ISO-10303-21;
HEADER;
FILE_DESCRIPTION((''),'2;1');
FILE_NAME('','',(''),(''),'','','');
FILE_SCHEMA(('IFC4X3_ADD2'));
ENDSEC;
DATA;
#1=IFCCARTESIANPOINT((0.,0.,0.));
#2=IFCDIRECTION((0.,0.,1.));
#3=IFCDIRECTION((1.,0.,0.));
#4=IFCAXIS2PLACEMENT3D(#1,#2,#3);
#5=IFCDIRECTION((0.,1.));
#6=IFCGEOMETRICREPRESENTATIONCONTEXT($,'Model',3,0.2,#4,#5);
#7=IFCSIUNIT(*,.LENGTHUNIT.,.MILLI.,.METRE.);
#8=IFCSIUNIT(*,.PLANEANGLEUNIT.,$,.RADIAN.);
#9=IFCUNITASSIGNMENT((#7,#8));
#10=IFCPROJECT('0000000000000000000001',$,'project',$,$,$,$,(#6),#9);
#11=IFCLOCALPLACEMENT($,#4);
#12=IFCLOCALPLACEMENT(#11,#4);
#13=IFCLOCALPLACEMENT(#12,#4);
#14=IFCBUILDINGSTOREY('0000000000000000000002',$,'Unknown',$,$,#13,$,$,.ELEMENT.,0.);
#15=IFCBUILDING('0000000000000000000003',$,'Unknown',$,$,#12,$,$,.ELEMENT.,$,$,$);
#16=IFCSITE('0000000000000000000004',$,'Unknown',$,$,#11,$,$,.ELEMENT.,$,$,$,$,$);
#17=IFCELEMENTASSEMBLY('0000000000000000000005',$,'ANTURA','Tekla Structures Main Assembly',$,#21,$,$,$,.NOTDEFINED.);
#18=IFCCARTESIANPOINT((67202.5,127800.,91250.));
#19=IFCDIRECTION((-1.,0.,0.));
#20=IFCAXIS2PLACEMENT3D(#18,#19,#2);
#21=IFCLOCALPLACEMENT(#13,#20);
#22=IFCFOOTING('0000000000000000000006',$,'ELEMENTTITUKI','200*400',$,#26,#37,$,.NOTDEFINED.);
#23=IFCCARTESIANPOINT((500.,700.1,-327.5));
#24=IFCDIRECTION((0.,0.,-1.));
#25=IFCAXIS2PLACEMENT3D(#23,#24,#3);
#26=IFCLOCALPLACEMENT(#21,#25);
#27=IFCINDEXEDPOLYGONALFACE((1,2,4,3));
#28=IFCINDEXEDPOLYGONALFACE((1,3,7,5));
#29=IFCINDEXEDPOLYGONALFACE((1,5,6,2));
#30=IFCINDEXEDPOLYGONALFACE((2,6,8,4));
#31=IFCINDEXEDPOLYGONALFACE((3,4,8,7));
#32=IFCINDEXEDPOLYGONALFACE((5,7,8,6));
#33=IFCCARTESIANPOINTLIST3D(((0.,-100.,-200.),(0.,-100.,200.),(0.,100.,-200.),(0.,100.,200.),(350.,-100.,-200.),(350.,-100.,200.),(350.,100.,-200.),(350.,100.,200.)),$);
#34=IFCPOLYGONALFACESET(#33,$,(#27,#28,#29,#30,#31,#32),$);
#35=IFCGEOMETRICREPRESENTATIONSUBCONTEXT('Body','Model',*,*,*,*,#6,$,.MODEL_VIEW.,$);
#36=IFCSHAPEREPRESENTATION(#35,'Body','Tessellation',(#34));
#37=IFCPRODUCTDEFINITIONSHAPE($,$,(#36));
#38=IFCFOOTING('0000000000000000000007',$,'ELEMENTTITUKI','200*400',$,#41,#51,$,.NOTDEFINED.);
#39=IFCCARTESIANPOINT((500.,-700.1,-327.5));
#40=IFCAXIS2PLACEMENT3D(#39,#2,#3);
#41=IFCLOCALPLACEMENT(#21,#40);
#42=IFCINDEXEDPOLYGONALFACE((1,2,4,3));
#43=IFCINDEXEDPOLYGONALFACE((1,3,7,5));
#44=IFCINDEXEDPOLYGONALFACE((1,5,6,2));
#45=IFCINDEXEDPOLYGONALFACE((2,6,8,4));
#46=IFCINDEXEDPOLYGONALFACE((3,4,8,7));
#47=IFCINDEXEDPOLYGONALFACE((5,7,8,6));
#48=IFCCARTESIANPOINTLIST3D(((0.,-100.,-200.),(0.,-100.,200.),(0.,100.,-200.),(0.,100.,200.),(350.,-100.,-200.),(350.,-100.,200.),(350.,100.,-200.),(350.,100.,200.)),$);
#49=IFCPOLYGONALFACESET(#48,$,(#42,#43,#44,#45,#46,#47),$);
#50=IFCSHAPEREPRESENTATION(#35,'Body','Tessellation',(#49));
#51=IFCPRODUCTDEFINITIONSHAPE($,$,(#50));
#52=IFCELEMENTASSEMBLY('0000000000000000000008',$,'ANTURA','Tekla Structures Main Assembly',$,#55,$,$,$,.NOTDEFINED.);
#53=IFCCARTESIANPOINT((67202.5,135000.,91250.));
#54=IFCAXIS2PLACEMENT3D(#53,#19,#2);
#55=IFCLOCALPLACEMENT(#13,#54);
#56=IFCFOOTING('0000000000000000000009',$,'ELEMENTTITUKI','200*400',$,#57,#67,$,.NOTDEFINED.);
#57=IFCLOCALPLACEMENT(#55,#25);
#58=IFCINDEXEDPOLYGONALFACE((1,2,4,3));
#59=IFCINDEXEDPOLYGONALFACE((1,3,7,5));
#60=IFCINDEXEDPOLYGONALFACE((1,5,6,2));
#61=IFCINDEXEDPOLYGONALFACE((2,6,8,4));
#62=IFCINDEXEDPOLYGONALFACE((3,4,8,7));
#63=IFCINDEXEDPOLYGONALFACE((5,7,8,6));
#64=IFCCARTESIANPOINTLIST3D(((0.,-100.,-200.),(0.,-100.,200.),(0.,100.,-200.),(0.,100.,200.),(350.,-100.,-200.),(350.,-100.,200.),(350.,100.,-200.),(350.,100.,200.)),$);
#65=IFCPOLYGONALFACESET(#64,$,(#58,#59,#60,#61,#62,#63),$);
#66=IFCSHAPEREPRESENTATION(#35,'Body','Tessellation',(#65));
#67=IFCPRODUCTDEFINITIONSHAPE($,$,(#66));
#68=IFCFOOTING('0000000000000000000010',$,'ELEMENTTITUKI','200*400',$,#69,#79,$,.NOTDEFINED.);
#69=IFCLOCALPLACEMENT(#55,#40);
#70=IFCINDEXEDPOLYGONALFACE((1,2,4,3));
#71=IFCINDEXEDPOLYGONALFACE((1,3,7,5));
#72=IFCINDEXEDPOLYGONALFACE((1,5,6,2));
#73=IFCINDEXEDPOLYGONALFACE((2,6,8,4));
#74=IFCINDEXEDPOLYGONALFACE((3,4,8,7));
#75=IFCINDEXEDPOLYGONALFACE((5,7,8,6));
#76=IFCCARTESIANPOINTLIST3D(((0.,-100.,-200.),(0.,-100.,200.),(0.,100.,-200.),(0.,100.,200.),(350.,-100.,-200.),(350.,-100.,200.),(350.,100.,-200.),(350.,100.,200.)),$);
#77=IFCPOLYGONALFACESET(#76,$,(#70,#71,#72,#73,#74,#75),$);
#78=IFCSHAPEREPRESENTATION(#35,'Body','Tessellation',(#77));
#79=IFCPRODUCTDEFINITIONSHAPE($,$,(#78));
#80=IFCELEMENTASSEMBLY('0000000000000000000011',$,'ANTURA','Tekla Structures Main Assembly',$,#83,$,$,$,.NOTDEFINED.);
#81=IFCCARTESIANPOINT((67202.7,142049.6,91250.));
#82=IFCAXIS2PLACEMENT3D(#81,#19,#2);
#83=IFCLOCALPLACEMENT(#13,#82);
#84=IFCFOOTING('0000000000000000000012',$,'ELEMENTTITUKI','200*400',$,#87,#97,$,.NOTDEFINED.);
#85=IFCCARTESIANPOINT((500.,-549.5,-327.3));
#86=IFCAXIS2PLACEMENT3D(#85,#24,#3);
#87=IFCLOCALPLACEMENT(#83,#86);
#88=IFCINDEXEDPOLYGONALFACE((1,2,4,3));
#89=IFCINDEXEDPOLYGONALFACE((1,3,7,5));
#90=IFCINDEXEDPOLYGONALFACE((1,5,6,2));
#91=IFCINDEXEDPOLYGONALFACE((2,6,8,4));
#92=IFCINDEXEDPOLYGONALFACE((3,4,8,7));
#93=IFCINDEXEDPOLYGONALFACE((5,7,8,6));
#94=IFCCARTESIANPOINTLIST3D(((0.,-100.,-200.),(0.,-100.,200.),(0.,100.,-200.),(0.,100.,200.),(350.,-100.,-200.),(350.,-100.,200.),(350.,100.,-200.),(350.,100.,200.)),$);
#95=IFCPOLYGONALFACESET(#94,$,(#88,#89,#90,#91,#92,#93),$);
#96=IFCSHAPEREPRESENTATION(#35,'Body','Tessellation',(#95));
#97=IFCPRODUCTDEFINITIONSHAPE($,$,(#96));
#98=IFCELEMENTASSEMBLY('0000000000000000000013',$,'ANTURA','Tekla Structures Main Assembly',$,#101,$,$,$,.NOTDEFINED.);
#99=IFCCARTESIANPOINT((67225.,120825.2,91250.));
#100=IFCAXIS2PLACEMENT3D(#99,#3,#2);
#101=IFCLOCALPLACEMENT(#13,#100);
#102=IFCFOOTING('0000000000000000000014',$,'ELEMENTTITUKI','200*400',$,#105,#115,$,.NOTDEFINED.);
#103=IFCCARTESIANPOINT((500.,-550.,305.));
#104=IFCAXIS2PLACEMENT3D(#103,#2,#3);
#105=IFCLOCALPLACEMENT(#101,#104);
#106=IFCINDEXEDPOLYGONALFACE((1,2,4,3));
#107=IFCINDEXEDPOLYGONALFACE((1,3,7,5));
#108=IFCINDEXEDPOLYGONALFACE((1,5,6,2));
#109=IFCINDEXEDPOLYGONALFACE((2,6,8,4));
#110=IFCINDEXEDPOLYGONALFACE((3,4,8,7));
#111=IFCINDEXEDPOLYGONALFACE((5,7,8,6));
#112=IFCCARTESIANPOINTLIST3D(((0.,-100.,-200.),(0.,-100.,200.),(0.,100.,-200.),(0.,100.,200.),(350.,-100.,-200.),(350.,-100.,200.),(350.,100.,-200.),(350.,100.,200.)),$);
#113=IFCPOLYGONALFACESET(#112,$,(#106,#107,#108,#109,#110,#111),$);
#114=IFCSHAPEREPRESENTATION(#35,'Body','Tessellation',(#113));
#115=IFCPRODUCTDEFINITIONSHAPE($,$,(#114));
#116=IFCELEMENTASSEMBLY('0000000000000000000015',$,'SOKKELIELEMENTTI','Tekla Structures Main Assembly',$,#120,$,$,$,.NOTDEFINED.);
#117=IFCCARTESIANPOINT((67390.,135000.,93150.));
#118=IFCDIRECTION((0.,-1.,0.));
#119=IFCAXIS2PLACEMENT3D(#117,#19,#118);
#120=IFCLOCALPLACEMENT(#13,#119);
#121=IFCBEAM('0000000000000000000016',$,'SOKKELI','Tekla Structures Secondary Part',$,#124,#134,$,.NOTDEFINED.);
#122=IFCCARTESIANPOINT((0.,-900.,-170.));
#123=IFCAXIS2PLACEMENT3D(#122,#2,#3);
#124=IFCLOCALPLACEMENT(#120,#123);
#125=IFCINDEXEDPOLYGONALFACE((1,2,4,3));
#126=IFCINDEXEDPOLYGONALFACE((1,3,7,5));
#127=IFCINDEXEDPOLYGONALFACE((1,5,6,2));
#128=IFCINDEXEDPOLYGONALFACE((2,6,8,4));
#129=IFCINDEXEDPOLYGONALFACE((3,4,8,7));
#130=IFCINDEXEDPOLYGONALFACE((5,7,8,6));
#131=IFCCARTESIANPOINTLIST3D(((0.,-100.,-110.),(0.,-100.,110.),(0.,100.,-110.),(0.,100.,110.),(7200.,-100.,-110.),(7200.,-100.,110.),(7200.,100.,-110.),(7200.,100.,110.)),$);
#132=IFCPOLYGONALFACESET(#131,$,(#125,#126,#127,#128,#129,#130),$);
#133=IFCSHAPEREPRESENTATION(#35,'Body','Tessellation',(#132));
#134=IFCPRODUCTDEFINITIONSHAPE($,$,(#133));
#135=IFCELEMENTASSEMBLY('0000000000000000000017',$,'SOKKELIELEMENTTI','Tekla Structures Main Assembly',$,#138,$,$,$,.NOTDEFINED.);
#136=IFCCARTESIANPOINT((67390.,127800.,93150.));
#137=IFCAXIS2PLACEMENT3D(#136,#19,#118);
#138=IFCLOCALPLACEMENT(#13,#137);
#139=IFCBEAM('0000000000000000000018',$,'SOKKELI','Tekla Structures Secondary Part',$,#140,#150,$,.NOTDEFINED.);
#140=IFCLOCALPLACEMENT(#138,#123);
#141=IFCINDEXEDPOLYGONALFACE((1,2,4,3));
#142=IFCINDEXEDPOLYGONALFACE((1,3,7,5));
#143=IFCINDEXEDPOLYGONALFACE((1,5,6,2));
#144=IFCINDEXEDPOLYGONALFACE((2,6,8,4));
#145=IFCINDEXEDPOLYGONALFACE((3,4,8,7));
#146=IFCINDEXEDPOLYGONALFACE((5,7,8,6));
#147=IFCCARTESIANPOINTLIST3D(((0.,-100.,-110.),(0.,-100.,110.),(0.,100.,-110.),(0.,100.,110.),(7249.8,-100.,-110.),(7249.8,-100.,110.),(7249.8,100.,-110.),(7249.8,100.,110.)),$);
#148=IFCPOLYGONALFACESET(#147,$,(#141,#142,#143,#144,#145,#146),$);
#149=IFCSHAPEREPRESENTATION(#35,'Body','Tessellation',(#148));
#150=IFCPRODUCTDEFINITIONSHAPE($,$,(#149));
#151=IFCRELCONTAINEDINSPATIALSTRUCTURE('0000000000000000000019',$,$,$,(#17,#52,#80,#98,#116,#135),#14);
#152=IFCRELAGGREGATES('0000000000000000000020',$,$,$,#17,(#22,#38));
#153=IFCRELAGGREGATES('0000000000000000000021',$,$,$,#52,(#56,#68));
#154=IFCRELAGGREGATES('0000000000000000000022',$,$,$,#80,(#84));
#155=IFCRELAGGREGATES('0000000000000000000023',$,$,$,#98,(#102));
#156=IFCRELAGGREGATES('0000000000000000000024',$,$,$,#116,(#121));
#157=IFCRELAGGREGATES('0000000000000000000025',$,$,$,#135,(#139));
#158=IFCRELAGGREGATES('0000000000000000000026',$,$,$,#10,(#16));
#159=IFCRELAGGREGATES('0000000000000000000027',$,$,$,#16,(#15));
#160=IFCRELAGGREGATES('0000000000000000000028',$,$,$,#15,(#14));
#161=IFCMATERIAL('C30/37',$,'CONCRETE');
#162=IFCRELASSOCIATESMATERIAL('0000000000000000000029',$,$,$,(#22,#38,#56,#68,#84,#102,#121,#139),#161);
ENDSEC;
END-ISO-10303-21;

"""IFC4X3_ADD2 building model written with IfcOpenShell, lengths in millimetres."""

from ifc_helpers import new_model, si_unit, direction, frame, origin_with_axes, place, context, subcontext, project, spatial, line, indexed_curve, outline, extrude, material, element, aggregate, save


model = new_model("IFC4X3_ADD2")

# Units and contexts
model_context = context("Model", 3, precision=0.2, world=origin_with_axes(), true_north=direction((0.0, 1.0)))
body_context = subcontext(model_context, "Body", "Model", "MODEL_VIEW")
ifc_project = project(units=[si_unit("LENGTHUNIT", "METRE", prefix="MILLI"), si_unit("PLANEANGLEUNIT", "RADIAN")], contexts=[model_context])

# Site, building, storey
site_placement = place(None, origin_with_axes())
site = spatial("IfcSite", under=ifc_project, at=site_placement, Name="Unknown", CompositionType="ELEMENT")
building_placement = place(site_placement, origin_with_axes())
building = spatial("IfcBuilding", under=site, at=building_placement, Name="Unknown", CompositionType="ELEMENT")
storey_placement = place(building_placement, origin_with_axes())
storey = spatial("IfcBuildingStorey", under=building, at=storey_placement, Name="Unknown", CompositionType="ELEMENT", Elevation=0.0)

# Shared definitions
ifc_material_1 = material(Name="C30/37", Category="CONCRETE")

# Element assembly, footings
assembly_1_placement = place(storey_placement, frame((67202.5, 127800.0, 91250.0), z_axis=(-1.0, 0.0, 0.0), x_axis=(0.0, 0.0, 1.0)))
assembly_1 = element("IfcElementAssembly", 1, at=assembly_1_placement, inside=storey, Name="ANTURA", Description="Tekla Structures Main Assembly", PredefinedType="NOTDEFINED")
footing_1_placement = place(assembly_1_placement, frame((500.0, 700.1, -327.5), z_axis=(0.0, 0.0, -1.0), x_axis=(1.0, 0.0, 0.0)))
footing_1 = element("IfcFooting", 2, at=footing_1_placement, material=ifc_material_1, Name="ELEMENTTITUKI", Description="200*400", PredefinedType="NOTDEFINED", context=body_context, shape_type="SolidModel", body=[
    extrude(outline(indexed_curve([(-200.0, -100.0), (200.0, -100.0), (200.0, 100.0), (-200.0, 100.0)], segments=[line(1, 2, 3, 4, 1)])), frame((0.0, 0.0, 0.0), z_axis=(-1.0, 0.0, 0.0), x_axis=(0.0, 0.0, 1.0)), (0.0, 0.0, -1.0), 350.0),
])
footing_2_placement = place(assembly_1_placement, frame((500.0, -700.1, -327.5), z_axis=(0.0, 0.0, 1.0), x_axis=(1.0, 0.0, 0.0)))
footing_2 = element("IfcFooting", 3, at=footing_2_placement, material=ifc_material_1, Name="ELEMENTTITUKI", Description="200*400", PredefinedType="NOTDEFINED", context=body_context, shape_type="SolidModel", body=[
    extrude(outline(indexed_curve([(-200.0, -100.0), (200.0, -100.0), (200.0, 100.0), (-200.0, 100.0)], segments=[line(1, 2, 3, 4, 1)])), frame((0.0, 0.0, 0.0), z_axis=(-1.0, 0.0, 0.0), x_axis=(0.0, 0.0, 1.0)), (0.0, 0.0, -1.0), 350.0),
])
aggregate(assembly_1, [footing_1, footing_2])

# Element assembly, footings
assembly_2_placement = place(storey_placement, frame((67202.5, 135000.0, 91250.0), z_axis=(-1.0, 0.0, 0.0), x_axis=(0.0, 0.0, 1.0)))
assembly_2 = element("IfcElementAssembly", 4, at=assembly_2_placement, inside=storey, Name="ANTURA", Description="Tekla Structures Main Assembly", PredefinedType="NOTDEFINED")
footing_3_placement = place(assembly_2_placement, frame((500.0, 700.1, -327.5), z_axis=(0.0, 0.0, -1.0), x_axis=(1.0, 0.0, 0.0)))
footing_3 = element("IfcFooting", 5, at=footing_3_placement, material=ifc_material_1, Name="ELEMENTTITUKI", Description="200*400", PredefinedType="NOTDEFINED", context=body_context, shape_type="SolidModel", body=[
    extrude(outline(indexed_curve([(-200.0, -100.0), (200.0, -100.0), (200.0, 100.0), (-200.0, 100.0)], segments=[line(1, 2, 3, 4, 1)])), frame((0.0, 0.0, 0.0), z_axis=(-1.0, 0.0, 0.0), x_axis=(0.0, 0.0, 1.0)), (0.0, 0.0, -1.0), 350.0),
])
footing_4_placement = place(assembly_2_placement, frame((500.0, -700.1, -327.5), z_axis=(0.0, 0.0, 1.0), x_axis=(1.0, 0.0, 0.0)))
footing_4 = element("IfcFooting", 6, at=footing_4_placement, material=ifc_material_1, Name="ELEMENTTITUKI", Description="200*400", PredefinedType="NOTDEFINED", context=body_context, shape_type="SolidModel", body=[
    extrude(outline(indexed_curve([(-200.0, -100.0), (200.0, -100.0), (200.0, 100.0), (-200.0, 100.0)], segments=[line(1, 2, 3, 4, 1)])), frame((0.0, 0.0, 0.0), z_axis=(-1.0, 0.0, 0.0), x_axis=(0.0, 0.0, 1.0)), (0.0, 0.0, -1.0), 350.0),
])
aggregate(assembly_2, [footing_3, footing_4])

# Element assemblies, footings
assembly_3_placement = place(storey_placement, frame((67202.7, 142049.6, 91250.0), z_axis=(-1.0, 0.0, 0.0), x_axis=(0.0, 0.0, 1.0)))
assembly_3 = element("IfcElementAssembly", 7, at=assembly_3_placement, inside=storey, Name="ANTURA", Description="Tekla Structures Main Assembly", PredefinedType="NOTDEFINED")
footing_5_placement = place(assembly_3_placement, frame((500.0, -549.5, -327.3), z_axis=(0.0, 0.0, -1.0), x_axis=(1.0, 0.0, 0.0)))
footing_5 = element("IfcFooting", 8, at=footing_5_placement, material=ifc_material_1, Name="ELEMENTTITUKI", Description="200*400", PredefinedType="NOTDEFINED", context=body_context, shape_type="SolidModel", body=[
    extrude(outline(indexed_curve([(-200.0, -100.0), (200.0, -100.0), (200.0, 100.0), (-200.0, 100.0)], segments=[line(1, 2, 3, 4, 1)])), frame((0.0, 0.0, 0.0), z_axis=(-1.0, 0.0, 0.0), x_axis=(0.0, 0.0, 1.0)), (0.0, 0.0, -1.0), 350.0),
])
aggregate(assembly_3, [footing_5])
assembly_4_placement = place(storey_placement, frame((67225.0, 120825.2, 91250.0), z_axis=(1.0, 0.0, 0.0), x_axis=(0.0, 0.0, 1.0)))
assembly_4 = element("IfcElementAssembly", 9, at=assembly_4_placement, inside=storey, Name="ANTURA", Description="Tekla Structures Main Assembly", PredefinedType="NOTDEFINED")
footing_6_placement = place(assembly_4_placement, frame((500.0, -550.0, 305.0), z_axis=(0.0, 0.0, 1.0), x_axis=(1.0, 0.0, 0.0)))
footing_6 = element("IfcFooting", 10, at=footing_6_placement, material=ifc_material_1, Name="ELEMENTTITUKI", Description="200*400", PredefinedType="NOTDEFINED", context=body_context, shape_type="SolidModel", body=[
    extrude(outline(indexed_curve([(-200.0, -100.0), (200.0, -100.0), (200.0, 100.0), (-200.0, 100.0)], segments=[line(1, 2, 3, 4, 1)])), frame((0.0, 0.0, 0.0), z_axis=(-1.0, 0.0, 0.0), x_axis=(0.0, 0.0, 1.0)), (0.0, 0.0, -1.0), 350.0),
])
aggregate(assembly_4, [footing_6])

# Element assemblies, beams
assembly_5_placement = place(storey_placement, frame((67390.0, 135000.0, 93150.0), z_axis=(-1.0, 0.0, 0.0), x_axis=(0.0, -1.0, 0.0)))
assembly_5 = element("IfcElementAssembly", 11, at=assembly_5_placement, inside=storey, Name="SOKKELIELEMENTTI", Description="Tekla Structures Main Assembly", PredefinedType="NOTDEFINED")
beam_1_placement = place(assembly_5_placement, frame((0.0, -900.0, -170.0), z_axis=(0.0, 0.0, 1.0), x_axis=(1.0, 0.0, 0.0)))
beam_1 = element("IfcBeam", 12, at=beam_1_placement, material=ifc_material_1, Name="SOKKELI", Description="Tekla Structures Secondary Part", PredefinedType="NOTDEFINED", context=body_context, shape_type="SolidModel", body=[
    extrude(outline(indexed_curve([(-110.0, -100.0), (110.0, -100.0), (110.0, 100.0), (-110.0, 100.0)], segments=[line(1, 2, 3, 4, 1)])), frame((0.0, 0.0, 0.0), z_axis=(-1.0, 0.0, 0.0), x_axis=(0.0, 0.0, 1.0)), (0.0, 0.0, -1.0), 7200.0),
])
aggregate(assembly_5, [beam_1])
assembly_6_placement = place(storey_placement, frame((67390.0, 127800.0, 93150.0), z_axis=(-1.0, 0.0, 0.0), x_axis=(0.0, -1.0, 0.0)))
assembly_6 = element("IfcElementAssembly", 13, at=assembly_6_placement, inside=storey, Name="SOKKELIELEMENTTI", Description="Tekla Structures Main Assembly", PredefinedType="NOTDEFINED")
beam_2_placement = place(assembly_6_placement, frame((0.0, -900.0, -170.0), z_axis=(0.0, 0.0, 1.0), x_axis=(1.0, 0.0, 0.0)))
beam_2 = element("IfcBeam", 14, at=beam_2_placement, material=ifc_material_1, Name="SOKKELI", Description="Tekla Structures Secondary Part", PredefinedType="NOTDEFINED", context=body_context, shape_type="SolidModel", body=[
    extrude(outline(indexed_curve([(-110.0, -100.0), (110.0, -100.0), (110.0, 100.0), (-110.0, 100.0)], segments=[line(1, 2, 3, 4, 1)])), frame((0.0, 0.0, 0.0), z_axis=(-1.0, 0.0, 0.0), x_axis=(0.0, 0.0, 1.0)), (0.0, 0.0, -1.0), 7249.8),
])
aggregate(assembly_6, [beam_2])

save(model, "model.ifc")
